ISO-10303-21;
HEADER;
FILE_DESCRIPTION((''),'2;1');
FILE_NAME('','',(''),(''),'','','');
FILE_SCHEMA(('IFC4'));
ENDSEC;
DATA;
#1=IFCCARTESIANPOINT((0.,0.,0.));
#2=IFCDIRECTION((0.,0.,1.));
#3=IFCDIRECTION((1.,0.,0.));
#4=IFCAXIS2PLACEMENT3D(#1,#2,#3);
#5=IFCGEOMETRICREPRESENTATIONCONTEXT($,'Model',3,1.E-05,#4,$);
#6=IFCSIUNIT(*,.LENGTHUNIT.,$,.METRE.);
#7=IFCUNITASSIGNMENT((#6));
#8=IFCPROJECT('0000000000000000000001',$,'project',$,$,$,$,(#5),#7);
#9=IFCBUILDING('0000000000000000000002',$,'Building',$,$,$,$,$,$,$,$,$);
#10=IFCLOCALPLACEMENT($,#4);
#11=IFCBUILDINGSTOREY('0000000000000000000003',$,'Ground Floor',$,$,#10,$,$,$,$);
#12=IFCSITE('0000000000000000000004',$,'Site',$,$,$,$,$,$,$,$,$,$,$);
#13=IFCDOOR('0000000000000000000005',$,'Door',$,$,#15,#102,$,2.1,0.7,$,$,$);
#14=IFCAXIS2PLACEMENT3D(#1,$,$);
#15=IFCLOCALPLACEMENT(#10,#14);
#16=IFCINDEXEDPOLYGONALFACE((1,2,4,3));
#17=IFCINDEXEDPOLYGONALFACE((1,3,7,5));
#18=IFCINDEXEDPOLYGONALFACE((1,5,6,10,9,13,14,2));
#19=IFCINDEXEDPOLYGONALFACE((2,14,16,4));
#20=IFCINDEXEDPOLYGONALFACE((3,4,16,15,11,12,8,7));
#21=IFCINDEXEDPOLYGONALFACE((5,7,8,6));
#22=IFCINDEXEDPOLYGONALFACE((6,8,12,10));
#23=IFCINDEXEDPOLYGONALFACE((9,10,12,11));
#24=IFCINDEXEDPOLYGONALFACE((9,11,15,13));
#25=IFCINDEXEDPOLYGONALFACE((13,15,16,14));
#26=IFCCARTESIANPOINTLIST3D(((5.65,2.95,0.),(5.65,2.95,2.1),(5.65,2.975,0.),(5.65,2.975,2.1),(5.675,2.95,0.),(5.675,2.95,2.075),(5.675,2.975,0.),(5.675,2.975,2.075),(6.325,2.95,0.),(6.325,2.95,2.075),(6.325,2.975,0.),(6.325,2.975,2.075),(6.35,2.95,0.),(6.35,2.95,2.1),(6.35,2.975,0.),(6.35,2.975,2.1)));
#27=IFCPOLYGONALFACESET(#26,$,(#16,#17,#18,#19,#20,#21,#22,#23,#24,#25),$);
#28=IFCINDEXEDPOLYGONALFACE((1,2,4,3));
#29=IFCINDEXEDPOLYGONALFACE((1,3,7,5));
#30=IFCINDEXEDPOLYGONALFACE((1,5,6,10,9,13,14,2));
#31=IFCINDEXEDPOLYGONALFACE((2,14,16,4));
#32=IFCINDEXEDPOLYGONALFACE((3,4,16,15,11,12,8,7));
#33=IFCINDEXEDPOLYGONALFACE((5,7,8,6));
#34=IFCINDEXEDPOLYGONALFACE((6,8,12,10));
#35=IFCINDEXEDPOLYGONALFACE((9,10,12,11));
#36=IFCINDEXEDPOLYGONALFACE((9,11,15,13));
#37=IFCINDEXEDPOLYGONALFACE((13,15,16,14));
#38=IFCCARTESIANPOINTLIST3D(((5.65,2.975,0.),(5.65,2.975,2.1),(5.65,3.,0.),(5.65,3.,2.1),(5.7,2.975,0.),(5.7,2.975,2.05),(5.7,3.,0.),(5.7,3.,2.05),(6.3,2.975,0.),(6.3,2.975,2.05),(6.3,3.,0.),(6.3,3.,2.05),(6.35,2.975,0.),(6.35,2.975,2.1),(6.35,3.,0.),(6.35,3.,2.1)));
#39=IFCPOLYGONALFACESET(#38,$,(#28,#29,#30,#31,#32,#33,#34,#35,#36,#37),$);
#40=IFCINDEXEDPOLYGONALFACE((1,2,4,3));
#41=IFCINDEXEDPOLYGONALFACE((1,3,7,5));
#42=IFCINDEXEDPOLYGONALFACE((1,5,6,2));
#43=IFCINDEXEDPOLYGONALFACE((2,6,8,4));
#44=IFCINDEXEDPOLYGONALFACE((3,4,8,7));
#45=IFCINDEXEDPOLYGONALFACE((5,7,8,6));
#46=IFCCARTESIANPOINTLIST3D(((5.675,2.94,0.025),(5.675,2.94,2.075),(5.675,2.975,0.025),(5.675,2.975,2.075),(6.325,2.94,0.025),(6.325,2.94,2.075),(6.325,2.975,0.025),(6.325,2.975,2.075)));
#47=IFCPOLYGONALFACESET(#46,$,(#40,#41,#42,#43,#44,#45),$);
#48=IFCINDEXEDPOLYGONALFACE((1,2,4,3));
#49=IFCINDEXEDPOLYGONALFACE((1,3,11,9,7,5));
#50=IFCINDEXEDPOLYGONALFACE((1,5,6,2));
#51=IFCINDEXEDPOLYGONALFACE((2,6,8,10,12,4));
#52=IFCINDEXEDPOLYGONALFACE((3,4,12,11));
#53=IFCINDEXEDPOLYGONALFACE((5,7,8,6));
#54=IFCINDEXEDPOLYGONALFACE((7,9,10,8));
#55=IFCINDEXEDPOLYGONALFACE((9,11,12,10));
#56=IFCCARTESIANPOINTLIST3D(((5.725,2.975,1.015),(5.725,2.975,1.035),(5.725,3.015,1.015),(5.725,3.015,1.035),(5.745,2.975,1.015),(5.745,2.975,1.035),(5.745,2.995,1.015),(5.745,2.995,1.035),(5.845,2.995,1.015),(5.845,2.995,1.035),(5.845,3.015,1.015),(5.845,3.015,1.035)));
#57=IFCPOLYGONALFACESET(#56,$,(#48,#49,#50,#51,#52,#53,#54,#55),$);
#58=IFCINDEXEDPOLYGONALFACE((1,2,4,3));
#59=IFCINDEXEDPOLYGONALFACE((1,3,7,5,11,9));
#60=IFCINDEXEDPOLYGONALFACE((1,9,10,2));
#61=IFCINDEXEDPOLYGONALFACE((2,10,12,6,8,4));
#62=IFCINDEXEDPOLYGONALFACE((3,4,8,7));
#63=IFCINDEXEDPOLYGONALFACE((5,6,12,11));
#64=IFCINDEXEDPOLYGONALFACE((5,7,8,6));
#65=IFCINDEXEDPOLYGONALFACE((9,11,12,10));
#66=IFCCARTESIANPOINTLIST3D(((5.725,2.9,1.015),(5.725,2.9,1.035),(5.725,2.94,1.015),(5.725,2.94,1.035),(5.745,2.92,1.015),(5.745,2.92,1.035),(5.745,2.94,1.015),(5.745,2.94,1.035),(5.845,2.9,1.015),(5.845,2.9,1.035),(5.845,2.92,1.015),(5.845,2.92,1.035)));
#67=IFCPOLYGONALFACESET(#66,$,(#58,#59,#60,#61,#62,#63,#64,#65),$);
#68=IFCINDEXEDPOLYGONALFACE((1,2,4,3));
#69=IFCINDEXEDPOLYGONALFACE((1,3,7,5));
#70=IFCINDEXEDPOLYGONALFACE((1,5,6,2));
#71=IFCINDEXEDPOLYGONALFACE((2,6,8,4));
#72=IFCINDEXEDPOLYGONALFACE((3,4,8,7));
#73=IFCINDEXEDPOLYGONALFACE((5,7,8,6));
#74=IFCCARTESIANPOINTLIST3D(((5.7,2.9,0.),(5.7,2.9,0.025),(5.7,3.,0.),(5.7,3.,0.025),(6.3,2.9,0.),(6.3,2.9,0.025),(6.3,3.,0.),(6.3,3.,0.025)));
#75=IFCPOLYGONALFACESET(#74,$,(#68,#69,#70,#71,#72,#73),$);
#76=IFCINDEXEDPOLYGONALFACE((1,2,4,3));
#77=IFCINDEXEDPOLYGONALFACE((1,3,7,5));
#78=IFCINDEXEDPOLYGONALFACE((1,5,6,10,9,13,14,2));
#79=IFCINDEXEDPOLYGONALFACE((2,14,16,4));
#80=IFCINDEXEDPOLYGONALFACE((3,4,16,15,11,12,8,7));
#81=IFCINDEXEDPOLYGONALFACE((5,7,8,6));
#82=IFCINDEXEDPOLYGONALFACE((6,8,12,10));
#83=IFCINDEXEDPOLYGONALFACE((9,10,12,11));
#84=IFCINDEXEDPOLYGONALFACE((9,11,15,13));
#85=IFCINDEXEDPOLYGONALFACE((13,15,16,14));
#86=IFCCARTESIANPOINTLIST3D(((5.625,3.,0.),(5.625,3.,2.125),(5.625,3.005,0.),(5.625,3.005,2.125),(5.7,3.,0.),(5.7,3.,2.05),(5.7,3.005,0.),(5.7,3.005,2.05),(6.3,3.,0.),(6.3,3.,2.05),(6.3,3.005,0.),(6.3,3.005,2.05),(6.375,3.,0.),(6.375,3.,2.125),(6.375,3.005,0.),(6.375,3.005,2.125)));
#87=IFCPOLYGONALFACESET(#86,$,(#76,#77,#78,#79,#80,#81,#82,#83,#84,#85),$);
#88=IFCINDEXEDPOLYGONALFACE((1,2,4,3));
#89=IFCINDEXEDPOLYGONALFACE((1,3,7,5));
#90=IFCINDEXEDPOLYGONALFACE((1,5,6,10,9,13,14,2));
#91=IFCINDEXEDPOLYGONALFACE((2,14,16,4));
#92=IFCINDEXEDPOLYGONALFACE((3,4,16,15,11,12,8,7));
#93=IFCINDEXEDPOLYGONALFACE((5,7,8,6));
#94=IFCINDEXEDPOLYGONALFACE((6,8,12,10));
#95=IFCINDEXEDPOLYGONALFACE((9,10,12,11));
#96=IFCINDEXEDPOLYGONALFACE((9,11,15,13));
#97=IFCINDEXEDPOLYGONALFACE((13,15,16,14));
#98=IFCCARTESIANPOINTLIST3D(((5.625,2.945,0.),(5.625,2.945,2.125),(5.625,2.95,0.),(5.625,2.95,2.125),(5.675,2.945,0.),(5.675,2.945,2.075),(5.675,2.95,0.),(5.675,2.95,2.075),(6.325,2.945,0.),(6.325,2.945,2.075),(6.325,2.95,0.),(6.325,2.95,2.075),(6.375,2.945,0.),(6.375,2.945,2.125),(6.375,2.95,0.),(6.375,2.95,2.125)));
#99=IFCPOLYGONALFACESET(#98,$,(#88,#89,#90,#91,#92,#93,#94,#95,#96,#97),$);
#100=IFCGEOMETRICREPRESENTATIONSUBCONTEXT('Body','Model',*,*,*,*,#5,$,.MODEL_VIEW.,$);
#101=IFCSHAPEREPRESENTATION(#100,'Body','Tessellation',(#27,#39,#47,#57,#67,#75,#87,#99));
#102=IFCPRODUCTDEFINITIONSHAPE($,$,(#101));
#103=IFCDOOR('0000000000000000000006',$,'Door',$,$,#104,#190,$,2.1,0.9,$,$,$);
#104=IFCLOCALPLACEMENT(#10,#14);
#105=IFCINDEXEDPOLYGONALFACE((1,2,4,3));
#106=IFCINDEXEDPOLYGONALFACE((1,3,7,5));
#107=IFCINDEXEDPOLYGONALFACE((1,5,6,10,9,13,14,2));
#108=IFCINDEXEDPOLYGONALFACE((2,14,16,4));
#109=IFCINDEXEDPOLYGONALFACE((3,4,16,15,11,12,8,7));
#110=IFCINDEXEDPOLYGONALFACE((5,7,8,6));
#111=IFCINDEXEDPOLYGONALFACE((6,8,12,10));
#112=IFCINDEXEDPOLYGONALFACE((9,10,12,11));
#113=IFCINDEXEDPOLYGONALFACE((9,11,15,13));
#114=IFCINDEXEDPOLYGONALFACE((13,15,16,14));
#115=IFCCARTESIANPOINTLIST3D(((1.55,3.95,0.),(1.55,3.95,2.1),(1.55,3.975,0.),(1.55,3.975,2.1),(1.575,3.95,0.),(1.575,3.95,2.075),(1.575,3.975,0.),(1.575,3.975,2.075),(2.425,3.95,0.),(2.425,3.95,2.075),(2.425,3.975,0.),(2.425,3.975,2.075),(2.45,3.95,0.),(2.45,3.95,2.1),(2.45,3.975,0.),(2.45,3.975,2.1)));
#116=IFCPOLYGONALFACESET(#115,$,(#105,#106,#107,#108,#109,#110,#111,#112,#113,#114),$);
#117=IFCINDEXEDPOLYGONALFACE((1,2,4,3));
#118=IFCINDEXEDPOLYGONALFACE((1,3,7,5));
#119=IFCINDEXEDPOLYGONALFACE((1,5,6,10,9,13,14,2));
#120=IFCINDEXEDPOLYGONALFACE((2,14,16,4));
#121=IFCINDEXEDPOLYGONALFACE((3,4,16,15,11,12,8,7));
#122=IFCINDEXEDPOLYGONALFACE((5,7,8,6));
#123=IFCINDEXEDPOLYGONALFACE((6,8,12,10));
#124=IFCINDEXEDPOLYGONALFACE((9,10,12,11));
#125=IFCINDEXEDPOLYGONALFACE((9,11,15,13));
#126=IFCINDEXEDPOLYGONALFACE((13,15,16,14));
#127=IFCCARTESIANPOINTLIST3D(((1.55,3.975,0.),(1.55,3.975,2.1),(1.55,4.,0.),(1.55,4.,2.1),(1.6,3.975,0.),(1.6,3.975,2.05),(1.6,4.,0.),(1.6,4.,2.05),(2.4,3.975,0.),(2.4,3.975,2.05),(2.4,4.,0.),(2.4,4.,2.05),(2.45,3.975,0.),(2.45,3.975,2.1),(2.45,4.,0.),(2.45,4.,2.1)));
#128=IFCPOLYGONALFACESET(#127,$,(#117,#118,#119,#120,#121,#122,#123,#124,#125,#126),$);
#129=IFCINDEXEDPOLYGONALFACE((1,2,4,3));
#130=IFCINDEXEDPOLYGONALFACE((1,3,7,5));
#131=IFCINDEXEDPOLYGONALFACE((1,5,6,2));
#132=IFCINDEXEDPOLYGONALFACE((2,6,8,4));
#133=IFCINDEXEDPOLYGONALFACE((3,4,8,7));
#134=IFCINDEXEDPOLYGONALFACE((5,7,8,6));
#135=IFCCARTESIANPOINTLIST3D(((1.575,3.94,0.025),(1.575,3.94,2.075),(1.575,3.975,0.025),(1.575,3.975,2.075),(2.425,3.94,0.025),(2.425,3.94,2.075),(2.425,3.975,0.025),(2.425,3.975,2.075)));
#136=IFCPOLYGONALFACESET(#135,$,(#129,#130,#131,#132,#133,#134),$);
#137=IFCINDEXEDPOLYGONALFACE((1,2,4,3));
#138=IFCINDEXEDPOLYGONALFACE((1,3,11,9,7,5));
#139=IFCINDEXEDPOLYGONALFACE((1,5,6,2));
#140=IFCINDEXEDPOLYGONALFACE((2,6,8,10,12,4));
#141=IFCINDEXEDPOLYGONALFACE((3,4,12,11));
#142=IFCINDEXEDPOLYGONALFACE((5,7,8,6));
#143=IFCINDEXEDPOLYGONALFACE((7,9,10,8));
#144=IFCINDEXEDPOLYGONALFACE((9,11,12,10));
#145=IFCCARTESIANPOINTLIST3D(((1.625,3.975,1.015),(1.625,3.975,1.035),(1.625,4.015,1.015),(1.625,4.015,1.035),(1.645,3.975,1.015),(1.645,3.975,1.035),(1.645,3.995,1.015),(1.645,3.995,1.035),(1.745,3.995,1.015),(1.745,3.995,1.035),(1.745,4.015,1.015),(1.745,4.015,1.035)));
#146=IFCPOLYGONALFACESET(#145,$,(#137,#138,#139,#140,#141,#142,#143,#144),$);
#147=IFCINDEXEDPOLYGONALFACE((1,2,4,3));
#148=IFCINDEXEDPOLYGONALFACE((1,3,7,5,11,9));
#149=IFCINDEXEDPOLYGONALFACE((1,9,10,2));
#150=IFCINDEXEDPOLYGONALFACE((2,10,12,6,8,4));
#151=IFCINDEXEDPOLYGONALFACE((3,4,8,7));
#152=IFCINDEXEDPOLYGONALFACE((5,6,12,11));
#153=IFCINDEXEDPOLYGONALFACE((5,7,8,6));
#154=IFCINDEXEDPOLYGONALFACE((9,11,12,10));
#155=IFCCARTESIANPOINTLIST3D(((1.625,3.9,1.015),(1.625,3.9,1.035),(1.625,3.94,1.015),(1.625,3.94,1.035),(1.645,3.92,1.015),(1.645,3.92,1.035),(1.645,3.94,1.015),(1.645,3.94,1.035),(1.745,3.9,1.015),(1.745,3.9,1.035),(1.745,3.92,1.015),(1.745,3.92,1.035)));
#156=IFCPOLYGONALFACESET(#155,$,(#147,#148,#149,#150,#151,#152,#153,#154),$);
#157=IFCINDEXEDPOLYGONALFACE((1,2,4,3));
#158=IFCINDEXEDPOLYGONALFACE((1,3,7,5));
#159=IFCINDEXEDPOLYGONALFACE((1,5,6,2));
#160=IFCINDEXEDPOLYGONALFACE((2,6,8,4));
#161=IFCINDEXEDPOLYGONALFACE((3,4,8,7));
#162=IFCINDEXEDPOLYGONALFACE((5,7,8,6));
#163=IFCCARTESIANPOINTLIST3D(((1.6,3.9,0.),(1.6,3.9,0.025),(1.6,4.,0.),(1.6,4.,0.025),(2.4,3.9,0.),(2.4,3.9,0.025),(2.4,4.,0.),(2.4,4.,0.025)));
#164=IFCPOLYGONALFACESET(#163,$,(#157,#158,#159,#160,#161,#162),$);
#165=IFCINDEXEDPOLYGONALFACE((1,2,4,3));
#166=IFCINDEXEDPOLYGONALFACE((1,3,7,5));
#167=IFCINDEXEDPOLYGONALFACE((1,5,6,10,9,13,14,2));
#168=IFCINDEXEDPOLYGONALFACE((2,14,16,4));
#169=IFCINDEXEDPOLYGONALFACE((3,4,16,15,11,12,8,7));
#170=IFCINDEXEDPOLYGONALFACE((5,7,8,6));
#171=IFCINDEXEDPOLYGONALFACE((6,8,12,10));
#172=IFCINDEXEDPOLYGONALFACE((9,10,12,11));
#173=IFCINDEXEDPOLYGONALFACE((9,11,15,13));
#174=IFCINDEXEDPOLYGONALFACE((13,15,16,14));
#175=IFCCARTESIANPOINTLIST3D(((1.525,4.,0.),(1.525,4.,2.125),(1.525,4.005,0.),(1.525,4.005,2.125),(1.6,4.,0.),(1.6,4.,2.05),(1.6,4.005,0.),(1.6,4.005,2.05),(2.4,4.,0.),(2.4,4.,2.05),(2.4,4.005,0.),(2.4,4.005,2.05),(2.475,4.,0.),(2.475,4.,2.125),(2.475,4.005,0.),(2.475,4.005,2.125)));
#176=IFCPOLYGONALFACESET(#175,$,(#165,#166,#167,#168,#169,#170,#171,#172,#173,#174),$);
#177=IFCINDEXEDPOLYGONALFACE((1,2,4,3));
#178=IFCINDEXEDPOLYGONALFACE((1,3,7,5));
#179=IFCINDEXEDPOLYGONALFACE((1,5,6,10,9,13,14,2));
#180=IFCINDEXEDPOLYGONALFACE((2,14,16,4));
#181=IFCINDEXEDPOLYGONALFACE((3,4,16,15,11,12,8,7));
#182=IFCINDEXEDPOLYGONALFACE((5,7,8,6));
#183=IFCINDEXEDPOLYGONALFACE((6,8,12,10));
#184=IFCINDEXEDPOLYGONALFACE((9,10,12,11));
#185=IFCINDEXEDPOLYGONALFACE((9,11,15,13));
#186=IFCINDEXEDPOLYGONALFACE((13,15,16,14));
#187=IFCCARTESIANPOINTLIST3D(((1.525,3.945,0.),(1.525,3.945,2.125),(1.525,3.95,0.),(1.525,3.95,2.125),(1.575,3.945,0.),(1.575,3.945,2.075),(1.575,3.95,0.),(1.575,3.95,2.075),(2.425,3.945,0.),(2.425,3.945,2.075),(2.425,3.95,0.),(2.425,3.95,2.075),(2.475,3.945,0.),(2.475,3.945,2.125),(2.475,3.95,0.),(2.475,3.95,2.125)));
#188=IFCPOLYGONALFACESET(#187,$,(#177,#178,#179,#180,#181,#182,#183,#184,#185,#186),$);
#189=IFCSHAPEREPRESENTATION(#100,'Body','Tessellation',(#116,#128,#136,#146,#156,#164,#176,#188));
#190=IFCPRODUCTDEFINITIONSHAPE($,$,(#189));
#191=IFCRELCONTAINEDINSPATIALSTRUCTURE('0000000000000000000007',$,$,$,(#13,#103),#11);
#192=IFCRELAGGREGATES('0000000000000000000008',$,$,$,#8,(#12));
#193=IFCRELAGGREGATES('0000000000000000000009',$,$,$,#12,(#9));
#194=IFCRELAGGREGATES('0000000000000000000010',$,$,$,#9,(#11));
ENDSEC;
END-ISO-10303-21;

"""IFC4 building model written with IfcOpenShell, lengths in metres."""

from ifc_helpers import new_model, si_unit, frame, origin_with_axes, place, context, subcontext, project, spatial, line, indexed_curve, outline, extrude, element, save


model = new_model("IFC4")

# Units and contexts
model_context = context("Model", 3, precision=1e-05, world=origin_with_axes())
body_context = subcontext(model_context, "Body", "Model", "MODEL_VIEW")
ifc_project = project(units=[si_unit("LENGTHUNIT", "METRE")], contexts=[model_context])

# Site, building, storey
site = spatial("IfcSite", under=ifc_project, Name="Site")
building = spatial("IfcBuilding", under=site, Name="Building")
storey_placement = place(None, origin_with_axes())
storey = spatial("IfcBuildingStorey", under=building, at=storey_placement, Name="Ground Floor")

# Doors
door_1_placement = place(storey_placement, frame((6.35, 3.0, 0.0), z_axis=(0.0, 0.0, 1.0), x_axis=(-1.0, 0.0, 0.0)))
element("IfcDoor", 1, at=door_1_placement, inside=storey, Name="Door", OverallHeight=2.1, OverallWidth=0.7, context=body_context, shape_type="SweptSolid", body=[
    extrude(outline(indexed_curve([(0.0, 0.0), (0.0, 2.1), (0.7, 2.1), (0.7, 0.0), (0.675, 0.0), (0.675, 2.075), (0.025, 2.075), (0.025, 0.0)], segments=[line(1, 2, 3, 4, 5, 6, 7, 8, 1)])), frame((0.0, 0.025, 0.0), z_axis=(0.0, -1.0, 0.0), x_axis=(1.0, 0.0, 0.0)), (0.0, 0.0, -1.0), 0.025),
    extrude(outline(indexed_curve([(0.0, 0.0), (0.0, 2.1), (0.7, 2.1), (0.7, 0.0), (0.65, 0.0), (0.65, 2.05), (0.05, 2.05), (0.05, 0.0)], segments=[line(1, 2, 3, 4, 5, 6, 7, 8, 1)])), frame((0.0, 0.0, 0.0), z_axis=(0.0, -1.0, 0.0), x_axis=(1.0, 0.0, 0.0)), (0.0, 0.0, -1.0), 0.025),
    extrude(outline(indexed_curve([(0.0, 0.0), (0.65, 0.0), (0.65, 0.035), (0.0, 0.035)], segments=[line(1, 2, 3, 4, 1)])), frame((0.025, 0.025, 0.025), z_axis=(0.0, 0.0, 1.0), x_axis=(1.0, 0.0, 0.0)), (0.0, 0.0, 1.0), 2.05),
    extrude(outline(indexed_curve([(0.0, 0.0), (0.0, -0.04), (-0.12, -0.04), (-0.12, -0.02), (-0.02, -0.02), (-0.02, 0.0)], segments=[line(1, 2, 3, 4, 5, 6, 1)])), frame((0.625, 0.025, 1.015), z_axis=(0.0, 0.0, 1.0), x_axis=(1.0, 0.0, 0.0)), (0.0, 0.0, 1.0), 0.02),
    extrude(outline(indexed_curve([(0.0, 0.0), (0.0, 0.04), (-0.12, 0.04), (-0.12, 0.02), (-0.02, 0.02), (-0.02, 0.0)], segments=[line(1, 2, 3, 4, 5, 6, 1)])), frame((0.625, 0.06, 1.015), z_axis=(0.0, 0.0, 1.0), x_axis=(1.0, 0.0, 0.0)), (0.0, 0.0, 1.0), 0.02),
    extrude(outline(indexed_curve([(0.0, 0.0), (0.6, 0.0), (0.6, 0.1), (0.0, 0.1)], segments=[line(1, 2, 3, 4, 1)])), frame((0.05, 0.0, 0.0), z_axis=(0.0, 0.0, 1.0), x_axis=(1.0, 0.0, 0.0)), (0.0, 0.0, 1.0), 0.025),
    extrude(outline(indexed_curve([(0.0, 0.0), (0.0, 2.125), (0.75, 2.125), (0.75, 0.0), (0.675, 0.0), (0.675, 2.05), (0.075, 2.05), (0.075, 0.0)], segments=[line(1, 2, 3, 4, 5, 6, 7, 8, 1)])), frame((-0.025, -0.005, 0.0), z_axis=(0.0, -1.0, 0.0), x_axis=(1.0, 0.0, 0.0)), (0.0, 0.0, -1.0), 0.005),
    extrude(outline(indexed_curve([(0.0, 0.0), (0.0, 2.125), (0.75, 2.125), (0.75, 0.0), (0.7, 0.0), (0.7, 2.075), (0.05, 2.075), (0.05, 0.0)], segments=[line(1, 2, 3, 4, 5, 6, 7, 8, 1)])), frame((-0.025, 0.05, 0.0), z_axis=(0.0, -1.0, 0.0), x_axis=(1.0, 0.0, 0.0)), (0.0, 0.0, -1.0), 0.005),
])
door_2_placement = place(storey_placement, frame((2.45, 4.0, 0.0), z_axis=(0.0, 0.0, 1.0), x_axis=(-1.0, 0.0, 0.0)))
element("IfcDoor", 2, at=door_2_placement, inside=storey, Name="Door", OverallHeight=2.1, OverallWidth=0.9, context=body_context, shape_type="SweptSolid", body=[
    extrude(outline(indexed_curve([(0.0, 0.0), (0.0, 2.1), (0.9, 2.1), (0.9, 0.0), (0.875, 0.0), (0.875, 2.075), (0.025, 2.075), (0.025, 0.0)], segments=[line(1, 2, 3, 4, 5, 6, 7, 8, 1)])), frame((0.0, 0.025, 0.0), z_axis=(0.0, -1.0, 0.0), x_axis=(1.0, 0.0, 0.0)), (0.0, 0.0, -1.0), 0.025),
    extrude(outline(indexed_curve([(0.0, 0.0), (0.0, 2.1), (0.9, 2.1), (0.9, 0.0), (0.85, 0.0), (0.85, 2.05), (0.05, 2.05), (0.05, 0.0)], segments=[line(1, 2, 3, 4, 5, 6, 7, 8, 1)])), frame((0.0, 0.0, 0.0), z_axis=(0.0, -1.0, 0.0), x_axis=(1.0, 0.0, 0.0)), (0.0, 0.0, -1.0), 0.025),
    extrude(outline(indexed_curve([(0.0, 0.0), (0.85, 0.0), (0.85, 0.035), (0.0, 0.035)], segments=[line(1, 2, 3, 4, 1)])), frame((0.025, 0.025, 0.025), z_axis=(0.0, 0.0, 1.0), x_axis=(1.0, 0.0, 0.0)), (0.0, 0.0, 1.0), 2.05),
    extrude(outline(indexed_curve([(0.0, 0.0), (0.0, -0.04), (-0.12, -0.04), (-0.12, -0.02), (-0.02, -0.02), (-0.02, 0.0)], segments=[line(1, 2, 3, 4, 5, 6, 1)])), frame((0.825, 0.025, 1.015), z_axis=(0.0, 0.0, 1.0), x_axis=(1.0, 0.0, 0.0)), (0.0, 0.0, 1.0), 0.02),
    extrude(outline(indexed_curve([(0.0, 0.0), (0.0, 0.04), (-0.12, 0.04), (-0.12, 0.02), (-0.02, 0.02), (-0.02, 0.0)], segments=[line(1, 2, 3, 4, 5, 6, 1)])), frame((0.825, 0.06, 1.015), z_axis=(0.0, 0.0, 1.0), x_axis=(1.0, 0.0, 0.0)), (0.0, 0.0, 1.0), 0.02),
    extrude(outline(indexed_curve([(0.0, 0.0), (0.8, 0.0), (0.8, 0.1), (0.0, 0.1)], segments=[line(1, 2, 3, 4, 1)])), frame((0.05, 0.0, 0.0), z_axis=(0.0, 0.0, 1.0), x_axis=(1.0, 0.0, 0.0)), (0.0, 0.0, 1.0), 0.025),
    extrude(outline(indexed_curve([(0.0, 0.0), (0.0, 2.125), (0.95, 2.125), (0.95, 0.0), (0.875, 0.0), (0.875, 2.05), (0.075, 2.05), (0.075, 0.0)], segments=[line(1, 2, 3, 4, 5, 6, 7, 8, 1)])), frame((-0.025, -0.005, 0.0), z_axis=(0.0, -1.0, 0.0), x_axis=(1.0, 0.0, 0.0)), (0.0, 0.0, -1.0), 0.005),
    extrude(outline(indexed_curve([(0.0, 0.0), (0.0, 2.125), (0.95, 2.125), (0.95, 0.0), (0.9, 0.0), (0.9, 2.075), (0.05, 2.075), (0.05, 0.0)], segments=[line(1, 2, 3, 4, 5, 6, 7, 8, 1)])), frame((-0.025, 0.05, 0.0), z_axis=(0.0, -1.0, 0.0), x_axis=(1.0, 0.0, 0.0)), (0.0, 0.0, -1.0), 0.005),
])

save(model, "model.ifc")
